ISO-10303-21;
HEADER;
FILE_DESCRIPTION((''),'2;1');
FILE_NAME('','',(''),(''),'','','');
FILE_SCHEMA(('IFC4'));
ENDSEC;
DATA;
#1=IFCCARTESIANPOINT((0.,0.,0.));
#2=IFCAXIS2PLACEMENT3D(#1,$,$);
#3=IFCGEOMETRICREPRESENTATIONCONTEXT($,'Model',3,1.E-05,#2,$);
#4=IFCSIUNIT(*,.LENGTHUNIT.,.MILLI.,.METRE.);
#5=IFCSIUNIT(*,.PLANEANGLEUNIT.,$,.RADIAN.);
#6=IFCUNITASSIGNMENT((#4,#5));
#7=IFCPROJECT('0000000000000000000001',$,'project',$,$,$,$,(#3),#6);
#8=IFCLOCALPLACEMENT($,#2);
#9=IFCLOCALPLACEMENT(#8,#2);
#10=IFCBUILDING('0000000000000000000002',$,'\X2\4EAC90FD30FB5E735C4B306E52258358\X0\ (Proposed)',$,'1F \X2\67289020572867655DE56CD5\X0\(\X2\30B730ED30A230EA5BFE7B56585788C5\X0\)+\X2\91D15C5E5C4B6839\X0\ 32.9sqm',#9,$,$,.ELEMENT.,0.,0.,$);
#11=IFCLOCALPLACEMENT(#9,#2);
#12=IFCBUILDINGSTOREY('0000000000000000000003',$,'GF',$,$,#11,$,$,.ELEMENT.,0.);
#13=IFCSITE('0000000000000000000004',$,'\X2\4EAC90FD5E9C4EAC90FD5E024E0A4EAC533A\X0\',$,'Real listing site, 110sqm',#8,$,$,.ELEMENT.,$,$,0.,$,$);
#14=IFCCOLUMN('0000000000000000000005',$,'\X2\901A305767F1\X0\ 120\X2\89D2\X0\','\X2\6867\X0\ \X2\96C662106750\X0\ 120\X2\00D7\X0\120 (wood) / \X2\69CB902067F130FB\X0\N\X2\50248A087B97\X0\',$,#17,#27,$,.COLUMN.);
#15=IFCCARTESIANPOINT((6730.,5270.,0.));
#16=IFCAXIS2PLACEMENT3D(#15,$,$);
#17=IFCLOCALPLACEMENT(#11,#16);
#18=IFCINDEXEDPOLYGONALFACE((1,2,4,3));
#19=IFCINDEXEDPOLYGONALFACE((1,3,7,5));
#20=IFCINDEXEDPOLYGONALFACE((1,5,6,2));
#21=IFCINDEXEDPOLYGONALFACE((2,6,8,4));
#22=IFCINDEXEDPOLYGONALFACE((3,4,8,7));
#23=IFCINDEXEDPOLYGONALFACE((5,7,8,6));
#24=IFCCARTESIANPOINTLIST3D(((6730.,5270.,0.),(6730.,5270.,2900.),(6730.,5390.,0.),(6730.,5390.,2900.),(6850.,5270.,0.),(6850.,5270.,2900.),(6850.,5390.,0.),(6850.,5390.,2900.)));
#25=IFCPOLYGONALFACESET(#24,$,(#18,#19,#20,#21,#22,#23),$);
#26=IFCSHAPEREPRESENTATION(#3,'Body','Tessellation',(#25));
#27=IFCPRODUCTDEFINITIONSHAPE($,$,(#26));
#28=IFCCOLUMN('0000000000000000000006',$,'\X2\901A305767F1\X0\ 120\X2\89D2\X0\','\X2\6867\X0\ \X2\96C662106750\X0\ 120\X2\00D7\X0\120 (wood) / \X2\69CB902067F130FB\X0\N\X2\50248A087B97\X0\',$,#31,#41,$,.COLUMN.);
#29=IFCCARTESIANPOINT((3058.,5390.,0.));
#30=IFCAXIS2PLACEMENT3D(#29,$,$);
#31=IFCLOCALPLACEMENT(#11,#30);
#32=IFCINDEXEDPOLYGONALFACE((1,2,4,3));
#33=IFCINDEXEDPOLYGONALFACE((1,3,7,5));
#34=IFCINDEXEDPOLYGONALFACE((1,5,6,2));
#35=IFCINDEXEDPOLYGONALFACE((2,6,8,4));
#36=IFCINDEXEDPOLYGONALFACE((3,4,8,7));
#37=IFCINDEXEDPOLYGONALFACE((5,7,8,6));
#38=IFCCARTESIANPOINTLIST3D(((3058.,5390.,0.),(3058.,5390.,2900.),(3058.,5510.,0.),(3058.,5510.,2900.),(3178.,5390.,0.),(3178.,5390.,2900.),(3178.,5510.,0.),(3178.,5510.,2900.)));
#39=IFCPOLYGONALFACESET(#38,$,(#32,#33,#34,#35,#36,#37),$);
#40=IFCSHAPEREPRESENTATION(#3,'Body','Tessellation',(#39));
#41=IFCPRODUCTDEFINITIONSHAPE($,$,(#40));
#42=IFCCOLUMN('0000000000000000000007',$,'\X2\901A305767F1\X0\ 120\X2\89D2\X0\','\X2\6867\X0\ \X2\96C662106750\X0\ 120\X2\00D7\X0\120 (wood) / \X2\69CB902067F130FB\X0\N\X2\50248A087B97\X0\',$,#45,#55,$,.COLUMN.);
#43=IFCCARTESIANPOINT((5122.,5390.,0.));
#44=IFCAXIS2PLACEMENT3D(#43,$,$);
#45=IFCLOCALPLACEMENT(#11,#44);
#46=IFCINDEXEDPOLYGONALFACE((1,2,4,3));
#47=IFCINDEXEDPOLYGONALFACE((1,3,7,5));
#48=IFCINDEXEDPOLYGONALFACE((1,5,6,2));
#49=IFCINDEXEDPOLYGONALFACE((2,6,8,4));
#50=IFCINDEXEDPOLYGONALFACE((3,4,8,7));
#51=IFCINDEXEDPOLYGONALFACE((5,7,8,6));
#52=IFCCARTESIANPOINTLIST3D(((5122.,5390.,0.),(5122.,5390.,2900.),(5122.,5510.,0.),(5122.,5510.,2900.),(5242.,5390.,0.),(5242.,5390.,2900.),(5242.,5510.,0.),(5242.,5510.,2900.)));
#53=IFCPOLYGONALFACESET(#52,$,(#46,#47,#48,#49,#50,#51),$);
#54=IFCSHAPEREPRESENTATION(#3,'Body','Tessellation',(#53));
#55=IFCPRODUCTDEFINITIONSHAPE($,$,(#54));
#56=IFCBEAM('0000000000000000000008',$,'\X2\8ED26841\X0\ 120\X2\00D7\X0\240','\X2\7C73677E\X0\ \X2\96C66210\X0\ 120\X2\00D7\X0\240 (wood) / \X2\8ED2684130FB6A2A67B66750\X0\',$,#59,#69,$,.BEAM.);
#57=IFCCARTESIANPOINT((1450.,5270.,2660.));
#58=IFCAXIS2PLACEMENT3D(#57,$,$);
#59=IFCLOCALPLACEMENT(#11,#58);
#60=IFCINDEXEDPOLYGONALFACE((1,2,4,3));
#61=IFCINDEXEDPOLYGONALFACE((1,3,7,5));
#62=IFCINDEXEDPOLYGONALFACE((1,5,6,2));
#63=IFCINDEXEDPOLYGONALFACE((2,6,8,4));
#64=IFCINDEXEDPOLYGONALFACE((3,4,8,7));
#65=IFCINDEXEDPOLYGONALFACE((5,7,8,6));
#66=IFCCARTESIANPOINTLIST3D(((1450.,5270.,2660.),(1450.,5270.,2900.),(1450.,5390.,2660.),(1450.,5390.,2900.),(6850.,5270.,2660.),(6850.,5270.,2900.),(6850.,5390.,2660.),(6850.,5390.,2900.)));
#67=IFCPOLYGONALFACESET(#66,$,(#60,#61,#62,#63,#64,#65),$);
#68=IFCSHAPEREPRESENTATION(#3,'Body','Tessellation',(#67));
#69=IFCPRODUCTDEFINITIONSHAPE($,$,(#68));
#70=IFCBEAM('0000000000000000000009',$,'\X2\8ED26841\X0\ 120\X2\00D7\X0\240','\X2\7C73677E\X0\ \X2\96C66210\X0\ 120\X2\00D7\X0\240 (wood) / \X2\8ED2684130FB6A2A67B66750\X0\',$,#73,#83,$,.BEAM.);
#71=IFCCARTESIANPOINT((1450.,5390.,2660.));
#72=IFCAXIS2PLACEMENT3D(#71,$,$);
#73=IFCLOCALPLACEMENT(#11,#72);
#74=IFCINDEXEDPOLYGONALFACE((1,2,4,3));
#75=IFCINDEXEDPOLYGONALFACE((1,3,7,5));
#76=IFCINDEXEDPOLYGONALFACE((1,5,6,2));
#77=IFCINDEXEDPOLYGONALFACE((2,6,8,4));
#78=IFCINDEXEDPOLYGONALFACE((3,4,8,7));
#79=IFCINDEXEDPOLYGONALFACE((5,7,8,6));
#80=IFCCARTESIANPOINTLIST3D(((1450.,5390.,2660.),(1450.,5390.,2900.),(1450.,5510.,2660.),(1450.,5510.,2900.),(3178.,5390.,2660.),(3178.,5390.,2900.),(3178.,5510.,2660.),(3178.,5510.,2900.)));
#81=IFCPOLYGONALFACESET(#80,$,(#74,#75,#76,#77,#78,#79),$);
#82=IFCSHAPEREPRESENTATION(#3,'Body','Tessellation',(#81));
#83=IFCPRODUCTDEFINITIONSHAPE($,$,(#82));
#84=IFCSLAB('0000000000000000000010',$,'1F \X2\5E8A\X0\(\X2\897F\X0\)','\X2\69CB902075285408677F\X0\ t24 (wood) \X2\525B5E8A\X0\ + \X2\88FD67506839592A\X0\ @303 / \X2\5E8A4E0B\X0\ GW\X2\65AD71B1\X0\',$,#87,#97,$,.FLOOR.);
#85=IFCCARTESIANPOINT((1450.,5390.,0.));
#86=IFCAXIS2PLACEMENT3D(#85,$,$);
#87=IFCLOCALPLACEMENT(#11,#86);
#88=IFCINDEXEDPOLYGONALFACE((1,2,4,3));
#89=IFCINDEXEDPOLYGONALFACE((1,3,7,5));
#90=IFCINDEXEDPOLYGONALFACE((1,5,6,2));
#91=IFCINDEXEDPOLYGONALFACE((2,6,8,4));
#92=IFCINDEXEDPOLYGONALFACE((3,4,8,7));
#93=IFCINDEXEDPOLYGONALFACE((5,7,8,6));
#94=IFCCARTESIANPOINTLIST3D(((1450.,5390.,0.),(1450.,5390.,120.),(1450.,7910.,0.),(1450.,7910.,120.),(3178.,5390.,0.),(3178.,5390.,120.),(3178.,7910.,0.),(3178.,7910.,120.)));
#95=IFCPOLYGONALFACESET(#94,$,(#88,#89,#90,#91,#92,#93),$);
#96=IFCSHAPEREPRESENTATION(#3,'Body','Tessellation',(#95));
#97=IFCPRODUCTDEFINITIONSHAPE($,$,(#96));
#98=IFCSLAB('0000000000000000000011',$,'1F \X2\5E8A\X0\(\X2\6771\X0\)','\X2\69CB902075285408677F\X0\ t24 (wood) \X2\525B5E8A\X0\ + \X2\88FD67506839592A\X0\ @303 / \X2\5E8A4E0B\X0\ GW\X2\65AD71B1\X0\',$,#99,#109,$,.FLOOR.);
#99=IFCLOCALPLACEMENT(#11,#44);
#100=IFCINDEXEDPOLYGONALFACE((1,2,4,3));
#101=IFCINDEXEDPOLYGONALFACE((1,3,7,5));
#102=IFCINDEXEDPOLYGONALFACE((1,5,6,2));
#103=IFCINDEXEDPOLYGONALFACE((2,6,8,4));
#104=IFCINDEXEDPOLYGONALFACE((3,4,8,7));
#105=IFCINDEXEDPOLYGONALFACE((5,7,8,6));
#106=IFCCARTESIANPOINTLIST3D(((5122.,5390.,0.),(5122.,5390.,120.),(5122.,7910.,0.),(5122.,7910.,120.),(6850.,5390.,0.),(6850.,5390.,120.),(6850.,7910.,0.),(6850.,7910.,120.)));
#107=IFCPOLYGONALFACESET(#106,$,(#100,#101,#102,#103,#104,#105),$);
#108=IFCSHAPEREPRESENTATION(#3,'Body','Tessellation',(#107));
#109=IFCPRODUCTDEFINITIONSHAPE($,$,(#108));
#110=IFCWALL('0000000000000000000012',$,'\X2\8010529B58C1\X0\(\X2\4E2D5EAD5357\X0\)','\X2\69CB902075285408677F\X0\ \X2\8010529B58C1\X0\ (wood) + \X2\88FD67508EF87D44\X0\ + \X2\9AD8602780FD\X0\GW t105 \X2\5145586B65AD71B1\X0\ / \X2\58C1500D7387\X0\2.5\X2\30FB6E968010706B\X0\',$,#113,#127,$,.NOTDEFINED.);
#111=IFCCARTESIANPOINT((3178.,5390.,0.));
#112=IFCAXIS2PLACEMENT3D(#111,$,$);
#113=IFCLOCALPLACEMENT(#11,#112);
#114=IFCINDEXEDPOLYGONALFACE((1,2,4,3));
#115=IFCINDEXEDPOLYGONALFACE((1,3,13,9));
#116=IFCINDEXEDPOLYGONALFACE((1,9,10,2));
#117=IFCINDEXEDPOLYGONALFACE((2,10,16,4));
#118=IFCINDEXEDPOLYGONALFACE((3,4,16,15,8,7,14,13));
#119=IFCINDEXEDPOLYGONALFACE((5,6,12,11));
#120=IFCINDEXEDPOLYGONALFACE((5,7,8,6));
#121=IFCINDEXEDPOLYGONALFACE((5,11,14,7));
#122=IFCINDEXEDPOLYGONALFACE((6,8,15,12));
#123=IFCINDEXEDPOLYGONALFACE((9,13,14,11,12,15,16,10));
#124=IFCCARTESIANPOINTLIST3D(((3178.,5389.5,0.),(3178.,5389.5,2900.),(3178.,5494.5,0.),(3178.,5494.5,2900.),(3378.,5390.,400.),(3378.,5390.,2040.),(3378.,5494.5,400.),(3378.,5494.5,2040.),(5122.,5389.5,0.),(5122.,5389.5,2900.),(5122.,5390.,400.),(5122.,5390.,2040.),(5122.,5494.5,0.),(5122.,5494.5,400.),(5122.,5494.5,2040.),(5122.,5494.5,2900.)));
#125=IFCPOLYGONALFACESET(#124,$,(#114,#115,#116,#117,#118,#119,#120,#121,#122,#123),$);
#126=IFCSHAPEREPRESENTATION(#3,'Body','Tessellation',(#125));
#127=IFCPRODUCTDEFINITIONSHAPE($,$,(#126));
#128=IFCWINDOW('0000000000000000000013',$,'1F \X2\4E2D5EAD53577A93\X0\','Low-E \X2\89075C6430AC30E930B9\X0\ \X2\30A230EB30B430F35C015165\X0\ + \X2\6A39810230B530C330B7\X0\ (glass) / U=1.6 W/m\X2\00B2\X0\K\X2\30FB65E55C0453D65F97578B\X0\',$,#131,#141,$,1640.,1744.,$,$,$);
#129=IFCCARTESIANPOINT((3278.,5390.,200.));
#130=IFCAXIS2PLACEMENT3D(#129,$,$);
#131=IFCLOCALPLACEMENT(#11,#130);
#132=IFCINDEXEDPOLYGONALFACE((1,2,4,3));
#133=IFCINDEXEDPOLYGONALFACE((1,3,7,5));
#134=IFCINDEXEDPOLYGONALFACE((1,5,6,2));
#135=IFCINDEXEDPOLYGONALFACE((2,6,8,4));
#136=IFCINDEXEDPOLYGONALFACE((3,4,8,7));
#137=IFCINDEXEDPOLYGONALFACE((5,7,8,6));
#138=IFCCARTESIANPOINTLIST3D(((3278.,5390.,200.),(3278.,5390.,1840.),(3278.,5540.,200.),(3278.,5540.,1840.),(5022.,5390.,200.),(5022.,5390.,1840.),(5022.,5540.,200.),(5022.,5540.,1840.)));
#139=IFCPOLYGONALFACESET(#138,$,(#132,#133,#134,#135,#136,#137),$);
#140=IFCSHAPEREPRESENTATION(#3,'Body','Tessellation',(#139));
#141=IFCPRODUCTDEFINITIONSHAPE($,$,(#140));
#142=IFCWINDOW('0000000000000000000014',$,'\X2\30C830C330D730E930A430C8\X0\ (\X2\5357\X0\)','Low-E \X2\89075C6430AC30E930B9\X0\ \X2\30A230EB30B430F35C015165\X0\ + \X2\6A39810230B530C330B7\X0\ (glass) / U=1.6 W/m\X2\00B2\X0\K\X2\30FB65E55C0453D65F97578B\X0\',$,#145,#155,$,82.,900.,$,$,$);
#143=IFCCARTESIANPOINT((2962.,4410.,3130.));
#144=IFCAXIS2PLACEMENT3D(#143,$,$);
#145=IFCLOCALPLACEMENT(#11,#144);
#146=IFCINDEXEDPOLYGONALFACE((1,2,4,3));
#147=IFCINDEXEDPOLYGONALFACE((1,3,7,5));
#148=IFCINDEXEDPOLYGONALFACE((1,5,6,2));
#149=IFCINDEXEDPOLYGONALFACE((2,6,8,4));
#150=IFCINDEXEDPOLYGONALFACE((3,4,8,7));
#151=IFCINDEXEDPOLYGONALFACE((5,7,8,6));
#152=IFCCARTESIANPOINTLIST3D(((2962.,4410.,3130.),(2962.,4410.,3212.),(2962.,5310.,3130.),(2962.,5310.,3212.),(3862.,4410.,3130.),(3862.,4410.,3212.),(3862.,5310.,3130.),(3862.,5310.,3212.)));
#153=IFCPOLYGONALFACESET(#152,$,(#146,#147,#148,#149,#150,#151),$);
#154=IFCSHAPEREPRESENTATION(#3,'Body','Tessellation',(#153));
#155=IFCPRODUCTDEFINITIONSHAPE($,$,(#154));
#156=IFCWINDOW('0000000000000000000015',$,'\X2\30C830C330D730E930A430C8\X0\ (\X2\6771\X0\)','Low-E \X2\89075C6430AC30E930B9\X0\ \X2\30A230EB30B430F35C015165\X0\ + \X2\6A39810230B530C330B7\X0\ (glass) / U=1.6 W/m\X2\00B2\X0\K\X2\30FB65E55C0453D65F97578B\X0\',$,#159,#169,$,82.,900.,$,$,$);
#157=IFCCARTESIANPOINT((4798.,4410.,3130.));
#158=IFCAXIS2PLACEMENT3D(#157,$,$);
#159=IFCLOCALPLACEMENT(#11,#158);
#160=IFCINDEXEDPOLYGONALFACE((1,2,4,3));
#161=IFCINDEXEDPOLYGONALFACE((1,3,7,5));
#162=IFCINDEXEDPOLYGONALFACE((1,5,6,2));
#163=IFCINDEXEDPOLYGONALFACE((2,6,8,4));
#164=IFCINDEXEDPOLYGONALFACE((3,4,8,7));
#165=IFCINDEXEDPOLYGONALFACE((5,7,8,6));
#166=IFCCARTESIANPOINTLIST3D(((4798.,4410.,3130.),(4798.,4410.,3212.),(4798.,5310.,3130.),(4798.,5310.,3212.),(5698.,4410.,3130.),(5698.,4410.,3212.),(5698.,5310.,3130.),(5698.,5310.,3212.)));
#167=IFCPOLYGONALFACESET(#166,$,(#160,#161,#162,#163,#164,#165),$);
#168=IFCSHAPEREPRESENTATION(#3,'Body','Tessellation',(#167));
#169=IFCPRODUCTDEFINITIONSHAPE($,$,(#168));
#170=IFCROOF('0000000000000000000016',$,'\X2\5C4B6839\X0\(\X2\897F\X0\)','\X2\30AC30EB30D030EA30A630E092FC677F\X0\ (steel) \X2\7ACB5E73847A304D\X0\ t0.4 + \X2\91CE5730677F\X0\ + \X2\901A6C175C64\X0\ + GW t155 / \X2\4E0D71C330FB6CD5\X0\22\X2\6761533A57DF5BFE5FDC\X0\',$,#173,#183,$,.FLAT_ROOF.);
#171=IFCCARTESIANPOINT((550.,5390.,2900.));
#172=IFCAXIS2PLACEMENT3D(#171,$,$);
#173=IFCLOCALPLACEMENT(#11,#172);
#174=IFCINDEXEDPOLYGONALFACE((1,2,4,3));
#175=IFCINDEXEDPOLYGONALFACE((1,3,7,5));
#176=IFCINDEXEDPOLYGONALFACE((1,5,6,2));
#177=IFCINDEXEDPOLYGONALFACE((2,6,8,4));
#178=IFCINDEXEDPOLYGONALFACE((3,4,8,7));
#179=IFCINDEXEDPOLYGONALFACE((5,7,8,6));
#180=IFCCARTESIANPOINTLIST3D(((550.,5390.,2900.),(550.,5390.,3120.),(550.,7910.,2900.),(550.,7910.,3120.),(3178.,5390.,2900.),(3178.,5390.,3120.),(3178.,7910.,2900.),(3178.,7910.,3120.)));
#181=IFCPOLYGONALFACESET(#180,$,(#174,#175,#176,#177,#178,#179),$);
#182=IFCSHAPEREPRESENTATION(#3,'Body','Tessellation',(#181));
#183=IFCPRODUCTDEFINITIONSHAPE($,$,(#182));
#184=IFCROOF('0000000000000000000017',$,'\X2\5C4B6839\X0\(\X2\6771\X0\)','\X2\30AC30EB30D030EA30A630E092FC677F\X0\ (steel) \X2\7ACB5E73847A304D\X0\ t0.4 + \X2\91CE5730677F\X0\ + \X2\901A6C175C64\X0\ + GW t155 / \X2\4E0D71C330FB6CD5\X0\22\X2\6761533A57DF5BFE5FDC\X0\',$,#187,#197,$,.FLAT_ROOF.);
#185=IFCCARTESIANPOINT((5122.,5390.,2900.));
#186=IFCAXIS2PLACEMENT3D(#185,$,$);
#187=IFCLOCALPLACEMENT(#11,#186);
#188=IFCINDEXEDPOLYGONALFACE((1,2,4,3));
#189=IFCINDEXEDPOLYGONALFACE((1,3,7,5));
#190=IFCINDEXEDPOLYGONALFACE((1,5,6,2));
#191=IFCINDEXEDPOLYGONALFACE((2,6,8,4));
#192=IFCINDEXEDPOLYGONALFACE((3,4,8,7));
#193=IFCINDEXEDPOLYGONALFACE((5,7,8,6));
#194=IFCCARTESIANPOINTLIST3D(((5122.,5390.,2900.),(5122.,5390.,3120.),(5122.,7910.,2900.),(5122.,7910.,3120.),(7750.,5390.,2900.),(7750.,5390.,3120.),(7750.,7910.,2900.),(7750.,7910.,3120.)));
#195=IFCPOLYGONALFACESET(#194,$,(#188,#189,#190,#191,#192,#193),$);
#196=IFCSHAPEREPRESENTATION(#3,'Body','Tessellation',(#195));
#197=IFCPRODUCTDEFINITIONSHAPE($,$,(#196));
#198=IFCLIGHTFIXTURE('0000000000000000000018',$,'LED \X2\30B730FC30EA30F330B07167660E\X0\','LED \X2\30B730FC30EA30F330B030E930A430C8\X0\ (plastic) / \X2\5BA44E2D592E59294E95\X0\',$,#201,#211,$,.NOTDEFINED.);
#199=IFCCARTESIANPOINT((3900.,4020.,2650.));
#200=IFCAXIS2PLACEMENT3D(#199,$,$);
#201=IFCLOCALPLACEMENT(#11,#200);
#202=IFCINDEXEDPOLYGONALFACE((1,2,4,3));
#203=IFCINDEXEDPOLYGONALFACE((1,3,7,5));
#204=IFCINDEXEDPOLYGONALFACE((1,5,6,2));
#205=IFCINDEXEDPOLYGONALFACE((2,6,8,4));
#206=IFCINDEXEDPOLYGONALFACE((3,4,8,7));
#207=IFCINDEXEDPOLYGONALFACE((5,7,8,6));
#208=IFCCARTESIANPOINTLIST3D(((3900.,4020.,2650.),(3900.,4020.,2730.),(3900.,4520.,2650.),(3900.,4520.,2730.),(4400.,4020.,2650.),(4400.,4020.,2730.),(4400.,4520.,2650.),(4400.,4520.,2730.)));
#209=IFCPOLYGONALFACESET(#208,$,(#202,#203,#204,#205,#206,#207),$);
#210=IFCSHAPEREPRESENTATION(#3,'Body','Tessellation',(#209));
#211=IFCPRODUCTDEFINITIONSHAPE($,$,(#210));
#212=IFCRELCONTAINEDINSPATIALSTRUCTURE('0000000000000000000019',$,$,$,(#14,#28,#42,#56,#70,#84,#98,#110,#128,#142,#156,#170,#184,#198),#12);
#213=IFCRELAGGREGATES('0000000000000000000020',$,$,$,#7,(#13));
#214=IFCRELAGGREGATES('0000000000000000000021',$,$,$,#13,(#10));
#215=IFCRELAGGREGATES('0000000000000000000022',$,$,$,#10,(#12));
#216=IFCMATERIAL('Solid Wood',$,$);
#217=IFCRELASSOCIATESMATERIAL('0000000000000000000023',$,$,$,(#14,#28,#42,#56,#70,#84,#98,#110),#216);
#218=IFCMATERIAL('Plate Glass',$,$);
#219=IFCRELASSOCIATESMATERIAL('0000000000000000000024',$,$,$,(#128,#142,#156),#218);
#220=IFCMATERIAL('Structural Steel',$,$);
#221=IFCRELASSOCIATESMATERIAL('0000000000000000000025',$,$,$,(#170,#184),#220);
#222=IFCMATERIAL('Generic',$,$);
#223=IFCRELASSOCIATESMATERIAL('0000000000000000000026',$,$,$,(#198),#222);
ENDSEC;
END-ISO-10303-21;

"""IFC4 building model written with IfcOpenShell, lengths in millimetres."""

from ifc_helpers import new_model, si_unit, frame, frame_2d, origin, place, context, project, spatial, rectangle, extrude, material, element, fill, save


model = new_model("IFC4")

# Units and contexts
model_context = context("Model", 3, precision=1e-05, world=origin())
ifc_project = project(units=[si_unit("LENGTHUNIT", "METRE", prefix="MILLI"), si_unit("PLANEANGLEUNIT", "RADIAN")], contexts=[model_context])

# Site, building, storey
site_placement = place(None, origin())
site = spatial("IfcSite", under=ifc_project, at=site_placement, Name="京都府京都市上京区", ObjectType="Real listing site, 110sqm", CompositionType="ELEMENT", RefElevation=0.0)
building_placement = place(site_placement, origin())
building = spatial("IfcBuilding", under=site, at=building_placement, Name="京都・平屋の別荘 (Proposed)", ObjectType="1F 木造在来工法(シロアリ対策塗装)+金属屋根 32.9sqm", CompositionType="ELEMENT", ElevationOfRefHeight=0.0, ElevationOfTerrain=0.0)
storey_placement = place(building_placement, origin())
storey = spatial("IfcBuildingStorey", under=building, at=storey_placement, Name="GF", CompositionType="ELEMENT", Elevation=0.0)

# Columns
ifc_material_1 = material(Name="Solid Wood")
column_1_placement = place(storey_placement, frame((6730.0, 5270.0, 0.0)))
element("IfcColumn", 1, at=column_1_placement, inside=storey, material=ifc_material_1, Name="通し柱 120角", Description="桧 集成材 120×120 (wood) / 構造柱・N値計算", PredefinedType="COLUMN", context=model_context, shape_type="SweptSolid", body=[
    extrude(rectangle(XDim=120.0, YDim=120.0, at=frame_2d((60.0, 60.0))), frame((6730.0, 5270.0, 0.0)), (0.0, 0.0, 1.0), 2900.0),
])
column_2_placement = place(storey_placement, frame((3058.0, 5390.0, 0.0)))
element("IfcColumn", 2, at=column_2_placement, inside=storey, material=ifc_material_1, Name="通し柱 120角", Description="桧 集成材 120×120 (wood) / 構造柱・N値計算", PredefinedType="COLUMN", context=model_context, shape_type="SweptSolid", body=[
    extrude(rectangle(XDim=120.0, YDim=120.0, at=frame_2d((60.0, 60.0))), frame((3058.0, 5390.0, 0.0)), (0.0, 0.0, 1.0), 2900.0),
])
column_3_placement = place(storey_placement, frame((5122.0, 5390.0, 0.0)))
element("IfcColumn", 3, at=column_3_placement, inside=storey, material=ifc_material_1, Name="通し柱 120角", Description="桧 集成材 120×120 (wood) / 構造柱・N値計算", PredefinedType="COLUMN", context=model_context, shape_type="SweptSolid", body=[
    extrude(rectangle(XDim=120.0, YDim=120.0, at=frame_2d((60.0, 60.0))), frame((5122.0, 5390.0, 0.0)), (0.0, 0.0, 1.0), 2900.0),
])

# Beams
beam_1_placement = place(storey_placement, frame((1450.0, 5270.0, 2660.0)))
element("IfcBeam", 4, at=beam_1_placement, inside=storey, material=ifc_material_1, Name="軒桁 120×240", Description="米松 集成 120×240 (wood) / 軒桁・横架材", PredefinedType="BEAM", context=model_context, shape_type="SweptSolid", body=[
    extrude(rectangle(XDim=5400.0, YDim=120.0, at=frame_2d((2700.0, 60.0))), frame((1450.0, 5270.0, 2660.0)), (0.0, 0.0, 1.0), 240.0),
])
beam_2_placement = place(storey_placement, frame((1450.0, 5390.0, 2660.0)))
element("IfcBeam", 5, at=beam_2_placement, inside=storey, material=ifc_material_1, Name="軒桁 120×240", Description="米松 集成 120×240 (wood) / 軒桁・横架材", PredefinedType="BEAM", context=model_context, shape_type="SweptSolid", body=[
    extrude(rectangle(XDim=1728.0, YDim=120.0, at=frame_2d((864.0, 60.0))), frame((1450.0, 5390.0, 2660.0)), (0.0, 0.0, 1.0), 240.0),
])

# Slabs
slab_1_placement = place(storey_placement, frame((1450.0, 5390.0, 0.0)))
element("IfcSlab", 6, at=slab_1_placement, inside=storey, material=ifc_material_1, Name="1F 床(西)", Description="構造用合板 t24 (wood) 剛床 + 製材根太 @303 / 床下 GW断熱", PredefinedType="FLOOR", context=model_context, shape_type="SweptSolid", body=[
    extrude(rectangle(XDim=1728.0, YDim=2520.0, at=frame_2d((864.0, 1260.0))), frame((1450.0, 5390.0, 0.0)), (0.0, 0.0, 1.0), 120.0),
])
slab_2_placement = place(storey_placement, frame((5122.0, 5390.0, 0.0)))
element("IfcSlab", 7, at=slab_2_placement, inside=storey, material=ifc_material_1, Name="1F 床(東)", Description="構造用合板 t24 (wood) 剛床 + 製材根太 @303 / 床下 GW断熱", PredefinedType="FLOOR", context=model_context, shape_type="SweptSolid", body=[
    extrude(rectangle(XDim=1728.0, YDim=2520.0, at=frame_2d((864.0, 1260.0))), frame((5122.0, 5390.0, 0.0)), (0.0, 0.0, 1.0), 120.0),
])

# Wall, opening, window
wall_1_placement = place(storey_placement, frame((3178.0, 5390.0, 0.0)))
wall_1 = element("IfcWall", 8, at=wall_1_placement, inside=storey, material=ifc_material_1, Name="耐力壁(中庭南)", Description="構造用合板 耐力壁 (wood) + 製材軸組 + 高性能GW t105 充填断熱 / 壁倍率2.5・準耐火", PredefinedType="NOTDEFINED", context=model_context, shape_type="SweptSolid", body=[
    extrude(rectangle(XDim=1944.0, YDim=105.0, at=frame_2d((972.0, 52.0))), frame((3178.0, 5390.0, 0.0)), (0.0, 0.0, 1.0), 2900.0),
])
opening_placement = place(storey_placement, frame((3278.0, 5390.0, 200.0)))
opening = element("IfcOpeningElement", 9, at=opening_placement, cuts=wall_1, PredefinedType="NOTDEFINED", context=model_context, shape_type="SweptSolid", body=[
    extrude(rectangle(XDim=1744.0, YDim=150.0, at=frame_2d((872.0, 75.0))), frame((3278.0, 5390.0, 200.0)), (0.0, 0.0, 1.0), 1640.0),
])
ifc_material_2 = material(Name="Plate Glass")
window_1_placement = place(storey_placement, frame((3278.0, 5390.0, 200.0)))
window_1 = element("IfcWindow", 10, at=window_1_placement, inside=storey, material=ifc_material_2, Name="1F 中庭南窓", Description="Low-E 複層ガラス アルゴン封入 + 樹脂サッシ (glass) / U=1.6 W/m²K・日射取得型", OverallHeight=1640.0, OverallWidth=1744.0, context=model_context, shape_type="SweptSolid", body=[
    extrude(rectangle(XDim=1744.0, YDim=150.0, at=frame_2d((872.0, 75.0))), frame((3278.0, 5390.0, 200.0)), (0.0, 0.0, 1.0), 1640.0),
])
fill(opening, window_1)

# Windows
window_2_placement = place(storey_placement, frame((2962.0, 4410.0, 3130.0)))
element("IfcWindow", 11, at=window_2_placement, inside=storey, material=ifc_material_2, Name="トップライト (南)", Description="Low-E 複層ガラス アルゴン封入 + 樹脂サッシ (glass) / U=1.6 W/m²K・日射取得型", OverallHeight=82.0, OverallWidth=900.0, context=model_context, shape_type="SweptSolid", body=[
    extrude(rectangle(XDim=900.0, YDim=900.0, at=frame_2d((450.0, 450.0))), frame((2962.0, 4410.0, 3130.0)), (0.0, 0.0, 1.0), 82.0),
])
window_3_placement = place(storey_placement, frame((4798.0, 4410.0, 3130.0)))
element("IfcWindow", 12, at=window_3_placement, inside=storey, material=ifc_material_2, Name="トップライト (東)", Description="Low-E 複層ガラス アルゴン封入 + 樹脂サッシ (glass) / U=1.6 W/m²K・日射取得型", OverallHeight=82.0, OverallWidth=900.0, context=model_context, shape_type="SweptSolid", body=[
    extrude(rectangle(XDim=900.0, YDim=900.0, at=frame_2d((450.0, 450.0))), frame((4798.0, 4410.0, 3130.0)), (0.0, 0.0, 1.0), 82.0),
])

# Roofs
ifc_material_3 = material(Name="Structural Steel")
roof_1_placement = place(storey_placement, frame((550.0, 5390.0, 2900.0)))
element("IfcRoof", 13, at=roof_1_placement, inside=storey, material=ifc_material_3, Name="屋根(西)", Description="ガルバリウム鋼板 (steel) 立平葺き t0.4 + 野地板 + 通気層 + GW t155 / 不燃・法22条区域対応", PredefinedType="FLAT_ROOF", context=model_context, shape_type="SweptSolid", body=[
    extrude(rectangle(XDim=2628.0, YDim=2520.0, at=frame_2d((1314.0, 1260.0))), frame((550.0, 5390.0, 2900.0)), (0.0, 0.0, 1.0), 220.0),
])
roof_2_placement = place(storey_placement, frame((5122.0, 5390.0, 2900.0)))
element("IfcRoof", 14, at=roof_2_placement, inside=storey, material=ifc_material_3, Name="屋根(東)", Description="ガルバリウム鋼板 (steel) 立平葺き t0.4 + 野地板 + 通気層 + GW t155 / 不燃・法22条区域対応", PredefinedType="FLAT_ROOF", context=model_context, shape_type="SweptSolid", body=[
    extrude(rectangle(XDim=2628.0, YDim=2520.0, at=frame_2d((1314.0, 1260.0))), frame((5122.0, 5390.0, 2900.0)), (0.0, 0.0, 1.0), 220.0),
])

# Light fixture
ifc_material_4 = material(Name="Generic")
light_fixture_placement = place(storey_placement, frame((3900.0, 4020.0, 2650.0)))
element("IfcLightFixture", 15, at=light_fixture_placement, inside=storey, material=ifc_material_4, Name="LED シーリング照明", Description="LED シーリングライト (plastic) / 室中央天井", PredefinedType="NOTDEFINED", context=model_context, shape_type="SweptSolid", body=[
    extrude(rectangle(XDim=500.0, YDim=500.0, at=frame_2d((250.0, 250.0))), frame((3900.0, 4020.0, 2650.0)), (0.0, 0.0, 1.0), 80.0),
])

save(model, "model.ifc")
